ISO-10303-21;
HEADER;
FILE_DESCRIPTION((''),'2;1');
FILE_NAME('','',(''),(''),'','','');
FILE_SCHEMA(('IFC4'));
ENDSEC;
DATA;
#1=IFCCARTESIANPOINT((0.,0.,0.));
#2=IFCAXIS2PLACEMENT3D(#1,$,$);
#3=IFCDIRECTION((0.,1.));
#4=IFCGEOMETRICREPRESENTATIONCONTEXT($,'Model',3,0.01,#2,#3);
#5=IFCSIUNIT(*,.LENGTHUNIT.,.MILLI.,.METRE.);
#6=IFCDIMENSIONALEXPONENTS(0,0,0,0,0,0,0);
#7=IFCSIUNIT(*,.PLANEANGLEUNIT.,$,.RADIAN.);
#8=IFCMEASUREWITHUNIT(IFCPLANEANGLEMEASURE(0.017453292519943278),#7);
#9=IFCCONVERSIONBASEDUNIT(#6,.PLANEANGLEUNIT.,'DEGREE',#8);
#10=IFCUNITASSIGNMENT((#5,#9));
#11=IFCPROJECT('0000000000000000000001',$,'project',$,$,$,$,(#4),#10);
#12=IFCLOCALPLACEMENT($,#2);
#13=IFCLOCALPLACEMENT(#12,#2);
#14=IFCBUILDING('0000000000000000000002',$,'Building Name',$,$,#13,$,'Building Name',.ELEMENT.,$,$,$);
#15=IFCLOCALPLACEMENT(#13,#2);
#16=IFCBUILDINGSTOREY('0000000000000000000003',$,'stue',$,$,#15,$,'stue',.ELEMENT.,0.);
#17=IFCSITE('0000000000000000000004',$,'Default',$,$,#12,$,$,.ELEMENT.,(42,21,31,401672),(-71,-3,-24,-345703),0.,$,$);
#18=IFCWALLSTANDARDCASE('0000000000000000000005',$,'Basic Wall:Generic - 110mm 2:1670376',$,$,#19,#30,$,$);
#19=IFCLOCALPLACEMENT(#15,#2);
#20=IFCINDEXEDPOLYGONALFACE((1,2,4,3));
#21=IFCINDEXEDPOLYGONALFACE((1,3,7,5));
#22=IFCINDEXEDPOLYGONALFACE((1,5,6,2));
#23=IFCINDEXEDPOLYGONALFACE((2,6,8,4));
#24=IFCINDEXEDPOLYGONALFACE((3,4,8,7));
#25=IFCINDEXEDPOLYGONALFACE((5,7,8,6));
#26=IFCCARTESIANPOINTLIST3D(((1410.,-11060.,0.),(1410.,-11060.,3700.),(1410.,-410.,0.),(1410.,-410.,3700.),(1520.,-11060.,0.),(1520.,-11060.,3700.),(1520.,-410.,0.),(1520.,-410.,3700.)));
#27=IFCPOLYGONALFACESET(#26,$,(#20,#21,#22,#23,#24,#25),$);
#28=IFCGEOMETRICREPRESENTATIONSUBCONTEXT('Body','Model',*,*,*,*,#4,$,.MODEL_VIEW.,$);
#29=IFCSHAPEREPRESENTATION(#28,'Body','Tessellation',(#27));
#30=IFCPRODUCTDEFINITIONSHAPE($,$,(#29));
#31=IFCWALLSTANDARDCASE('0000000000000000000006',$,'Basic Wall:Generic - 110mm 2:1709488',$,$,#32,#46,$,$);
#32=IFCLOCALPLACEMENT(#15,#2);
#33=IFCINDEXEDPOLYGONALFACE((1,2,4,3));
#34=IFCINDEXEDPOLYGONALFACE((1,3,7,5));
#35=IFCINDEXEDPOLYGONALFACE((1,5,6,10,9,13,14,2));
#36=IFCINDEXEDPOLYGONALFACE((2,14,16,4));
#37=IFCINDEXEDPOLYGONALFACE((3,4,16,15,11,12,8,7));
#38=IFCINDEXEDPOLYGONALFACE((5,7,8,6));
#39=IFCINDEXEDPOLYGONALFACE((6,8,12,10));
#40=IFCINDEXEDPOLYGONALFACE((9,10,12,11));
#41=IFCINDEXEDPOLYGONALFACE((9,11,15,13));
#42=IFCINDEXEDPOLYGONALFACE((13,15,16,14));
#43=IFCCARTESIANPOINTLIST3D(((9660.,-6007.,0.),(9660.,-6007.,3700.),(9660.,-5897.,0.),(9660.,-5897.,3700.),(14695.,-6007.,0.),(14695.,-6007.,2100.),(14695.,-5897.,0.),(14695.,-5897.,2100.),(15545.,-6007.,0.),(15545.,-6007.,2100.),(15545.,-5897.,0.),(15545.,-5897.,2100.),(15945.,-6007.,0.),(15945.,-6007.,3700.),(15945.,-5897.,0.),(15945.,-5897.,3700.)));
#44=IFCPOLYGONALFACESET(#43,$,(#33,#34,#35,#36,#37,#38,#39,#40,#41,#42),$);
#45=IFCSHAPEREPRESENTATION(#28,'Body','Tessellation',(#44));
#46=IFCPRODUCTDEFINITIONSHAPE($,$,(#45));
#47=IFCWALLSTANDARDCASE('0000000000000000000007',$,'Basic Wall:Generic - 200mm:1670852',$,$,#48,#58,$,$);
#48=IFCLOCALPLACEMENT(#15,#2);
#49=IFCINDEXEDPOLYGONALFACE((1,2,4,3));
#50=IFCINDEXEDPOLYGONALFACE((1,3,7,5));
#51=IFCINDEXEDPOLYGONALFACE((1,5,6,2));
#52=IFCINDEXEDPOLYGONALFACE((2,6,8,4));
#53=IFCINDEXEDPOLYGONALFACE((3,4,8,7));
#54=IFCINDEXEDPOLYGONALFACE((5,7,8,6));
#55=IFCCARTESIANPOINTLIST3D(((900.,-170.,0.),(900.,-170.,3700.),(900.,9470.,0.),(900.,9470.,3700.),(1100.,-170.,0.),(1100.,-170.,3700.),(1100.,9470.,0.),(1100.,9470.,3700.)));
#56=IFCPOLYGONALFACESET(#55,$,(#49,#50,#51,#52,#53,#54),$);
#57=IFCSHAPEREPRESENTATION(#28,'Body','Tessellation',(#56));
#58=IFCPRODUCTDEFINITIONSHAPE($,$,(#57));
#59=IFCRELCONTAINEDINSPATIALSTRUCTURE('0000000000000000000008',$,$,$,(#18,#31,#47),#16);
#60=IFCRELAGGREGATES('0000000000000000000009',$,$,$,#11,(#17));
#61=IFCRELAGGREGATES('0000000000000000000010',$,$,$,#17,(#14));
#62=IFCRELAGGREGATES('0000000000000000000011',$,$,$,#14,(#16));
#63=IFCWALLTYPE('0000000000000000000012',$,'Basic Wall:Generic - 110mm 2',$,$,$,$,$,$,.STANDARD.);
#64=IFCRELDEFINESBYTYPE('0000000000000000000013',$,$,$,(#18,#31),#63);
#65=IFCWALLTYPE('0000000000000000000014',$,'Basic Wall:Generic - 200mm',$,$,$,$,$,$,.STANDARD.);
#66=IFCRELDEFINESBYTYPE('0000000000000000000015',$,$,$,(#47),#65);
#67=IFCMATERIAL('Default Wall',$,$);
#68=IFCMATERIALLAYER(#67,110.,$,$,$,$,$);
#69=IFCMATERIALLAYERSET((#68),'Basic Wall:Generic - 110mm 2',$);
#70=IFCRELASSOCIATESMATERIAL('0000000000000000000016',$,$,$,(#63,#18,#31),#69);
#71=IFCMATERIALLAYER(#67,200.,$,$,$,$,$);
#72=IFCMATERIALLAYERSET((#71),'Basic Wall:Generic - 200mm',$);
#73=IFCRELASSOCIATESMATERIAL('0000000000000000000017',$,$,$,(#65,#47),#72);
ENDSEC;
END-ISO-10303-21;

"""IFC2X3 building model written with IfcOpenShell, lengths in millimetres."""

from ifc_helpers import new_model, entity, si_unit, converted_unit, direction, frame, frame_2d, origin, place, context, subcontext, project, spatial, polyline, rectangle, extrude, clip, bounded_halfspace, material, layer, layer_set, layer_usage, type_object, element, save


model = new_model("IFC2X3")

# Units and contexts
model_context = context("Model", 3, precision=0.01, world=origin(), true_north=direction((0.0, 1.0)))
body_context = subcontext(model_context, "Body", "Model", "MODEL_VIEW")
ifc_project = project(units=[si_unit("LENGTHUNIT", "METRE", prefix="MILLI"), converted_unit("PLANEANGLEUNIT", "DEGREE", entity("IfcPlaneAngleMeasure", 0.017453292519943278), si_unit("PLANEANGLEUNIT", "RADIAN"), dimensions=[0, 0, 0, 0, 0, 0, 0])], contexts=[model_context])

# Site, building, storey
site_placement = place(None, origin())
site = spatial("IfcSite", under=ifc_project, at=site_placement, Name="Default", CompositionType="ELEMENT", RefLatitude=(42, 21, 31, 401672), RefLongitude=(-71, -3, -24, -345703), RefElevation=0.0)
building_placement = place(site_placement, origin())
building = spatial("IfcBuilding", under=site, at=building_placement, Name="Building Name", LongName="Building Name", CompositionType="ELEMENT")
storey_placement = place(building_placement, origin())
storey = spatial("IfcBuildingStorey", under=building, at=storey_placement, Name="stue", LongName="stue", CompositionType="ELEMENT", Elevation=0.0)

# Wall
ifc_material_1 = material(Name="Default Wall")
ifc_layer_1 = layer(ifc_material_1, 110.0)
ifc_layer_set_1 = layer_set([ifc_layer_1], Name="Basic Wall:Generic - 110mm 2")
ifc_layer_usage_1 = layer_usage(ifc_layer_set_1, "AXIS2", "NEGATIVE", 55.0)
wall_type_1 = type_object("IfcWallType", Name="Basic Wall:Generic - 110mm 2", PredefinedType="STANDARD", material=ifc_layer_set_1)
wall_1_placement = place(storey_placement, frame((1465.0, -410.0, 0.0), z_axis=(0.0, 0.0, 1.0), x_axis=(0.0, -1.0, 0.0)))
element("IfcWallStandardCase", 1, at=wall_1_placement, inside=storey, type_object=wall_type_1, material=ifc_layer_usage_1, Name="Basic Wall:Generic - 110mm 2:1670376", context=body_context, shape_type="Clipping", body=[
    clip(extrude(rectangle(XDim=10650.0, YDim=110.0, at=frame_2d((5325.0, 0.0), x_axis=(-1.0, 0.0))), origin(), (0.0, 0.0, 1.0), 3700.0), bounded_halfspace(frame((0.0, -55.0, 3700.0), z_axis=(0.0, 0.0, -1.0), x_axis=(1.0, 0.0, 0.0)), True, frame((0.0, -55.0, 3700.0)), polyline([(0.0, 0.0), (5107.0, 0.0), (5217.0, 0.0), (10650.0, 0.0), (10650.0, 110.0), (0.0, 110.0), (0.0, 0.0)]))),
])

# Wall, opening
ifc_layer_usage_2 = layer_usage(ifc_layer_set_1, "AXIS2", "NEGATIVE", 55.0)
wall_2_placement = place(storey_placement, frame((9660.0, -5952.0, 0.0)))
wall_2 = element("IfcWallStandardCase", 2, at=wall_2_placement, inside=storey, type_object=wall_type_1, material=ifc_layer_usage_2, Name="Basic Wall:Generic - 110mm 2:1709488", context=body_context, shape_type="Clipping", body=[
    clip(extrude(rectangle(XDim=6285.0, YDim=110.0, at=frame_2d((3142.5, 0.0), x_axis=(-1.0, 0.0))), origin(), (0.0, 0.0, 1.0), 3700.0), bounded_halfspace(frame((0.0, -55.0, 3700.0), z_axis=(0.0, 0.0, -1.0), x_axis=(0.0, -1.0, 0.0)), True, frame((0.0, -55.0, 3700.0)), polyline([(0.0, 0.0), (4228.0, 0.0), (4338.0, 0.0), (6285.0, 0.0), (6285.0, 110.0), (0.0, 110.0), (0.0, 0.0)]))),
])
opening_1_placement = place(wall_2_placement, frame((5035.0, -55.0, 0.0)))
element("IfcOpeningElement", 3, at=opening_1_placement, cuts=wall_2, ObjectType="Opening", context=body_context, shape_type="SweptSolid", body=[
    extrude(rectangle(XDim=2100.0, YDim=850.0, at=frame_2d((1050.0, 425.0), x_axis=(1.0, 0.0))), frame((0.0, 0.0, 0.0), z_axis=(0.0, 1.0, 0.0), x_axis=(0.0, 0.0, 1.0)), (0.0, 0.0, 1.0), 110.0),
])

# Wall
ifc_layer_2 = layer(ifc_material_1, 200.0)
ifc_layer_set_2 = layer_set([ifc_layer_2], Name="Basic Wall:Generic - 200mm")
ifc_layer_usage_3 = layer_usage(ifc_layer_set_2, "AXIS2", "NEGATIVE", 100.0)
wall_type_2 = type_object("IfcWallType", Name="Basic Wall:Generic - 200mm", PredefinedType="STANDARD", material=ifc_layer_set_2)
wall_3_placement = place(storey_placement, frame((1000.0, 9470.0, 0.0), z_axis=(0.0, 0.0, 1.0), x_axis=(0.0, -1.0, 0.0)))
element("IfcWallStandardCase", 4, at=wall_3_placement, inside=storey, type_object=wall_type_2, material=ifc_layer_usage_3, Name="Basic Wall:Generic - 200mm:1670852", context=body_context, shape_type="Clipping", body=[
    clip(clip(extrude(rectangle(XDim=9640.0, YDim=200.0, at=frame_2d((4820.0, 0.0), x_axis=(-1.0, 0.0))), origin(), (0.0, 0.0, 1.0), 3700.0), bounded_halfspace(frame((0.0, -100.0, 3700.0), z_axis=(0.0, 0.0, -1.0), x_axis=(1.0, 0.0, 0.0)), True, frame((0.0, -100.0, 3700.0)), polyline([(0.0, 0.0), (9510.0, 0.0), (9510.0, 200.0), (0.0, 200.0), (0.0, 0.0)]))), bounded_halfspace(frame((9510.0, -100.0, 3700.0), z_axis=(0.0, 0.0, -1.0), x_axis=(1.0, 0.0, 0.0)), True, frame((9510.0, -100.0, 3700.0)), polyline([(0.0, 0.0), (130.0, 0.0), (130.0, 200.0), (0.0, 200.0), (0.0, 0.0)]))),
])

save(model, "model.ifc")
